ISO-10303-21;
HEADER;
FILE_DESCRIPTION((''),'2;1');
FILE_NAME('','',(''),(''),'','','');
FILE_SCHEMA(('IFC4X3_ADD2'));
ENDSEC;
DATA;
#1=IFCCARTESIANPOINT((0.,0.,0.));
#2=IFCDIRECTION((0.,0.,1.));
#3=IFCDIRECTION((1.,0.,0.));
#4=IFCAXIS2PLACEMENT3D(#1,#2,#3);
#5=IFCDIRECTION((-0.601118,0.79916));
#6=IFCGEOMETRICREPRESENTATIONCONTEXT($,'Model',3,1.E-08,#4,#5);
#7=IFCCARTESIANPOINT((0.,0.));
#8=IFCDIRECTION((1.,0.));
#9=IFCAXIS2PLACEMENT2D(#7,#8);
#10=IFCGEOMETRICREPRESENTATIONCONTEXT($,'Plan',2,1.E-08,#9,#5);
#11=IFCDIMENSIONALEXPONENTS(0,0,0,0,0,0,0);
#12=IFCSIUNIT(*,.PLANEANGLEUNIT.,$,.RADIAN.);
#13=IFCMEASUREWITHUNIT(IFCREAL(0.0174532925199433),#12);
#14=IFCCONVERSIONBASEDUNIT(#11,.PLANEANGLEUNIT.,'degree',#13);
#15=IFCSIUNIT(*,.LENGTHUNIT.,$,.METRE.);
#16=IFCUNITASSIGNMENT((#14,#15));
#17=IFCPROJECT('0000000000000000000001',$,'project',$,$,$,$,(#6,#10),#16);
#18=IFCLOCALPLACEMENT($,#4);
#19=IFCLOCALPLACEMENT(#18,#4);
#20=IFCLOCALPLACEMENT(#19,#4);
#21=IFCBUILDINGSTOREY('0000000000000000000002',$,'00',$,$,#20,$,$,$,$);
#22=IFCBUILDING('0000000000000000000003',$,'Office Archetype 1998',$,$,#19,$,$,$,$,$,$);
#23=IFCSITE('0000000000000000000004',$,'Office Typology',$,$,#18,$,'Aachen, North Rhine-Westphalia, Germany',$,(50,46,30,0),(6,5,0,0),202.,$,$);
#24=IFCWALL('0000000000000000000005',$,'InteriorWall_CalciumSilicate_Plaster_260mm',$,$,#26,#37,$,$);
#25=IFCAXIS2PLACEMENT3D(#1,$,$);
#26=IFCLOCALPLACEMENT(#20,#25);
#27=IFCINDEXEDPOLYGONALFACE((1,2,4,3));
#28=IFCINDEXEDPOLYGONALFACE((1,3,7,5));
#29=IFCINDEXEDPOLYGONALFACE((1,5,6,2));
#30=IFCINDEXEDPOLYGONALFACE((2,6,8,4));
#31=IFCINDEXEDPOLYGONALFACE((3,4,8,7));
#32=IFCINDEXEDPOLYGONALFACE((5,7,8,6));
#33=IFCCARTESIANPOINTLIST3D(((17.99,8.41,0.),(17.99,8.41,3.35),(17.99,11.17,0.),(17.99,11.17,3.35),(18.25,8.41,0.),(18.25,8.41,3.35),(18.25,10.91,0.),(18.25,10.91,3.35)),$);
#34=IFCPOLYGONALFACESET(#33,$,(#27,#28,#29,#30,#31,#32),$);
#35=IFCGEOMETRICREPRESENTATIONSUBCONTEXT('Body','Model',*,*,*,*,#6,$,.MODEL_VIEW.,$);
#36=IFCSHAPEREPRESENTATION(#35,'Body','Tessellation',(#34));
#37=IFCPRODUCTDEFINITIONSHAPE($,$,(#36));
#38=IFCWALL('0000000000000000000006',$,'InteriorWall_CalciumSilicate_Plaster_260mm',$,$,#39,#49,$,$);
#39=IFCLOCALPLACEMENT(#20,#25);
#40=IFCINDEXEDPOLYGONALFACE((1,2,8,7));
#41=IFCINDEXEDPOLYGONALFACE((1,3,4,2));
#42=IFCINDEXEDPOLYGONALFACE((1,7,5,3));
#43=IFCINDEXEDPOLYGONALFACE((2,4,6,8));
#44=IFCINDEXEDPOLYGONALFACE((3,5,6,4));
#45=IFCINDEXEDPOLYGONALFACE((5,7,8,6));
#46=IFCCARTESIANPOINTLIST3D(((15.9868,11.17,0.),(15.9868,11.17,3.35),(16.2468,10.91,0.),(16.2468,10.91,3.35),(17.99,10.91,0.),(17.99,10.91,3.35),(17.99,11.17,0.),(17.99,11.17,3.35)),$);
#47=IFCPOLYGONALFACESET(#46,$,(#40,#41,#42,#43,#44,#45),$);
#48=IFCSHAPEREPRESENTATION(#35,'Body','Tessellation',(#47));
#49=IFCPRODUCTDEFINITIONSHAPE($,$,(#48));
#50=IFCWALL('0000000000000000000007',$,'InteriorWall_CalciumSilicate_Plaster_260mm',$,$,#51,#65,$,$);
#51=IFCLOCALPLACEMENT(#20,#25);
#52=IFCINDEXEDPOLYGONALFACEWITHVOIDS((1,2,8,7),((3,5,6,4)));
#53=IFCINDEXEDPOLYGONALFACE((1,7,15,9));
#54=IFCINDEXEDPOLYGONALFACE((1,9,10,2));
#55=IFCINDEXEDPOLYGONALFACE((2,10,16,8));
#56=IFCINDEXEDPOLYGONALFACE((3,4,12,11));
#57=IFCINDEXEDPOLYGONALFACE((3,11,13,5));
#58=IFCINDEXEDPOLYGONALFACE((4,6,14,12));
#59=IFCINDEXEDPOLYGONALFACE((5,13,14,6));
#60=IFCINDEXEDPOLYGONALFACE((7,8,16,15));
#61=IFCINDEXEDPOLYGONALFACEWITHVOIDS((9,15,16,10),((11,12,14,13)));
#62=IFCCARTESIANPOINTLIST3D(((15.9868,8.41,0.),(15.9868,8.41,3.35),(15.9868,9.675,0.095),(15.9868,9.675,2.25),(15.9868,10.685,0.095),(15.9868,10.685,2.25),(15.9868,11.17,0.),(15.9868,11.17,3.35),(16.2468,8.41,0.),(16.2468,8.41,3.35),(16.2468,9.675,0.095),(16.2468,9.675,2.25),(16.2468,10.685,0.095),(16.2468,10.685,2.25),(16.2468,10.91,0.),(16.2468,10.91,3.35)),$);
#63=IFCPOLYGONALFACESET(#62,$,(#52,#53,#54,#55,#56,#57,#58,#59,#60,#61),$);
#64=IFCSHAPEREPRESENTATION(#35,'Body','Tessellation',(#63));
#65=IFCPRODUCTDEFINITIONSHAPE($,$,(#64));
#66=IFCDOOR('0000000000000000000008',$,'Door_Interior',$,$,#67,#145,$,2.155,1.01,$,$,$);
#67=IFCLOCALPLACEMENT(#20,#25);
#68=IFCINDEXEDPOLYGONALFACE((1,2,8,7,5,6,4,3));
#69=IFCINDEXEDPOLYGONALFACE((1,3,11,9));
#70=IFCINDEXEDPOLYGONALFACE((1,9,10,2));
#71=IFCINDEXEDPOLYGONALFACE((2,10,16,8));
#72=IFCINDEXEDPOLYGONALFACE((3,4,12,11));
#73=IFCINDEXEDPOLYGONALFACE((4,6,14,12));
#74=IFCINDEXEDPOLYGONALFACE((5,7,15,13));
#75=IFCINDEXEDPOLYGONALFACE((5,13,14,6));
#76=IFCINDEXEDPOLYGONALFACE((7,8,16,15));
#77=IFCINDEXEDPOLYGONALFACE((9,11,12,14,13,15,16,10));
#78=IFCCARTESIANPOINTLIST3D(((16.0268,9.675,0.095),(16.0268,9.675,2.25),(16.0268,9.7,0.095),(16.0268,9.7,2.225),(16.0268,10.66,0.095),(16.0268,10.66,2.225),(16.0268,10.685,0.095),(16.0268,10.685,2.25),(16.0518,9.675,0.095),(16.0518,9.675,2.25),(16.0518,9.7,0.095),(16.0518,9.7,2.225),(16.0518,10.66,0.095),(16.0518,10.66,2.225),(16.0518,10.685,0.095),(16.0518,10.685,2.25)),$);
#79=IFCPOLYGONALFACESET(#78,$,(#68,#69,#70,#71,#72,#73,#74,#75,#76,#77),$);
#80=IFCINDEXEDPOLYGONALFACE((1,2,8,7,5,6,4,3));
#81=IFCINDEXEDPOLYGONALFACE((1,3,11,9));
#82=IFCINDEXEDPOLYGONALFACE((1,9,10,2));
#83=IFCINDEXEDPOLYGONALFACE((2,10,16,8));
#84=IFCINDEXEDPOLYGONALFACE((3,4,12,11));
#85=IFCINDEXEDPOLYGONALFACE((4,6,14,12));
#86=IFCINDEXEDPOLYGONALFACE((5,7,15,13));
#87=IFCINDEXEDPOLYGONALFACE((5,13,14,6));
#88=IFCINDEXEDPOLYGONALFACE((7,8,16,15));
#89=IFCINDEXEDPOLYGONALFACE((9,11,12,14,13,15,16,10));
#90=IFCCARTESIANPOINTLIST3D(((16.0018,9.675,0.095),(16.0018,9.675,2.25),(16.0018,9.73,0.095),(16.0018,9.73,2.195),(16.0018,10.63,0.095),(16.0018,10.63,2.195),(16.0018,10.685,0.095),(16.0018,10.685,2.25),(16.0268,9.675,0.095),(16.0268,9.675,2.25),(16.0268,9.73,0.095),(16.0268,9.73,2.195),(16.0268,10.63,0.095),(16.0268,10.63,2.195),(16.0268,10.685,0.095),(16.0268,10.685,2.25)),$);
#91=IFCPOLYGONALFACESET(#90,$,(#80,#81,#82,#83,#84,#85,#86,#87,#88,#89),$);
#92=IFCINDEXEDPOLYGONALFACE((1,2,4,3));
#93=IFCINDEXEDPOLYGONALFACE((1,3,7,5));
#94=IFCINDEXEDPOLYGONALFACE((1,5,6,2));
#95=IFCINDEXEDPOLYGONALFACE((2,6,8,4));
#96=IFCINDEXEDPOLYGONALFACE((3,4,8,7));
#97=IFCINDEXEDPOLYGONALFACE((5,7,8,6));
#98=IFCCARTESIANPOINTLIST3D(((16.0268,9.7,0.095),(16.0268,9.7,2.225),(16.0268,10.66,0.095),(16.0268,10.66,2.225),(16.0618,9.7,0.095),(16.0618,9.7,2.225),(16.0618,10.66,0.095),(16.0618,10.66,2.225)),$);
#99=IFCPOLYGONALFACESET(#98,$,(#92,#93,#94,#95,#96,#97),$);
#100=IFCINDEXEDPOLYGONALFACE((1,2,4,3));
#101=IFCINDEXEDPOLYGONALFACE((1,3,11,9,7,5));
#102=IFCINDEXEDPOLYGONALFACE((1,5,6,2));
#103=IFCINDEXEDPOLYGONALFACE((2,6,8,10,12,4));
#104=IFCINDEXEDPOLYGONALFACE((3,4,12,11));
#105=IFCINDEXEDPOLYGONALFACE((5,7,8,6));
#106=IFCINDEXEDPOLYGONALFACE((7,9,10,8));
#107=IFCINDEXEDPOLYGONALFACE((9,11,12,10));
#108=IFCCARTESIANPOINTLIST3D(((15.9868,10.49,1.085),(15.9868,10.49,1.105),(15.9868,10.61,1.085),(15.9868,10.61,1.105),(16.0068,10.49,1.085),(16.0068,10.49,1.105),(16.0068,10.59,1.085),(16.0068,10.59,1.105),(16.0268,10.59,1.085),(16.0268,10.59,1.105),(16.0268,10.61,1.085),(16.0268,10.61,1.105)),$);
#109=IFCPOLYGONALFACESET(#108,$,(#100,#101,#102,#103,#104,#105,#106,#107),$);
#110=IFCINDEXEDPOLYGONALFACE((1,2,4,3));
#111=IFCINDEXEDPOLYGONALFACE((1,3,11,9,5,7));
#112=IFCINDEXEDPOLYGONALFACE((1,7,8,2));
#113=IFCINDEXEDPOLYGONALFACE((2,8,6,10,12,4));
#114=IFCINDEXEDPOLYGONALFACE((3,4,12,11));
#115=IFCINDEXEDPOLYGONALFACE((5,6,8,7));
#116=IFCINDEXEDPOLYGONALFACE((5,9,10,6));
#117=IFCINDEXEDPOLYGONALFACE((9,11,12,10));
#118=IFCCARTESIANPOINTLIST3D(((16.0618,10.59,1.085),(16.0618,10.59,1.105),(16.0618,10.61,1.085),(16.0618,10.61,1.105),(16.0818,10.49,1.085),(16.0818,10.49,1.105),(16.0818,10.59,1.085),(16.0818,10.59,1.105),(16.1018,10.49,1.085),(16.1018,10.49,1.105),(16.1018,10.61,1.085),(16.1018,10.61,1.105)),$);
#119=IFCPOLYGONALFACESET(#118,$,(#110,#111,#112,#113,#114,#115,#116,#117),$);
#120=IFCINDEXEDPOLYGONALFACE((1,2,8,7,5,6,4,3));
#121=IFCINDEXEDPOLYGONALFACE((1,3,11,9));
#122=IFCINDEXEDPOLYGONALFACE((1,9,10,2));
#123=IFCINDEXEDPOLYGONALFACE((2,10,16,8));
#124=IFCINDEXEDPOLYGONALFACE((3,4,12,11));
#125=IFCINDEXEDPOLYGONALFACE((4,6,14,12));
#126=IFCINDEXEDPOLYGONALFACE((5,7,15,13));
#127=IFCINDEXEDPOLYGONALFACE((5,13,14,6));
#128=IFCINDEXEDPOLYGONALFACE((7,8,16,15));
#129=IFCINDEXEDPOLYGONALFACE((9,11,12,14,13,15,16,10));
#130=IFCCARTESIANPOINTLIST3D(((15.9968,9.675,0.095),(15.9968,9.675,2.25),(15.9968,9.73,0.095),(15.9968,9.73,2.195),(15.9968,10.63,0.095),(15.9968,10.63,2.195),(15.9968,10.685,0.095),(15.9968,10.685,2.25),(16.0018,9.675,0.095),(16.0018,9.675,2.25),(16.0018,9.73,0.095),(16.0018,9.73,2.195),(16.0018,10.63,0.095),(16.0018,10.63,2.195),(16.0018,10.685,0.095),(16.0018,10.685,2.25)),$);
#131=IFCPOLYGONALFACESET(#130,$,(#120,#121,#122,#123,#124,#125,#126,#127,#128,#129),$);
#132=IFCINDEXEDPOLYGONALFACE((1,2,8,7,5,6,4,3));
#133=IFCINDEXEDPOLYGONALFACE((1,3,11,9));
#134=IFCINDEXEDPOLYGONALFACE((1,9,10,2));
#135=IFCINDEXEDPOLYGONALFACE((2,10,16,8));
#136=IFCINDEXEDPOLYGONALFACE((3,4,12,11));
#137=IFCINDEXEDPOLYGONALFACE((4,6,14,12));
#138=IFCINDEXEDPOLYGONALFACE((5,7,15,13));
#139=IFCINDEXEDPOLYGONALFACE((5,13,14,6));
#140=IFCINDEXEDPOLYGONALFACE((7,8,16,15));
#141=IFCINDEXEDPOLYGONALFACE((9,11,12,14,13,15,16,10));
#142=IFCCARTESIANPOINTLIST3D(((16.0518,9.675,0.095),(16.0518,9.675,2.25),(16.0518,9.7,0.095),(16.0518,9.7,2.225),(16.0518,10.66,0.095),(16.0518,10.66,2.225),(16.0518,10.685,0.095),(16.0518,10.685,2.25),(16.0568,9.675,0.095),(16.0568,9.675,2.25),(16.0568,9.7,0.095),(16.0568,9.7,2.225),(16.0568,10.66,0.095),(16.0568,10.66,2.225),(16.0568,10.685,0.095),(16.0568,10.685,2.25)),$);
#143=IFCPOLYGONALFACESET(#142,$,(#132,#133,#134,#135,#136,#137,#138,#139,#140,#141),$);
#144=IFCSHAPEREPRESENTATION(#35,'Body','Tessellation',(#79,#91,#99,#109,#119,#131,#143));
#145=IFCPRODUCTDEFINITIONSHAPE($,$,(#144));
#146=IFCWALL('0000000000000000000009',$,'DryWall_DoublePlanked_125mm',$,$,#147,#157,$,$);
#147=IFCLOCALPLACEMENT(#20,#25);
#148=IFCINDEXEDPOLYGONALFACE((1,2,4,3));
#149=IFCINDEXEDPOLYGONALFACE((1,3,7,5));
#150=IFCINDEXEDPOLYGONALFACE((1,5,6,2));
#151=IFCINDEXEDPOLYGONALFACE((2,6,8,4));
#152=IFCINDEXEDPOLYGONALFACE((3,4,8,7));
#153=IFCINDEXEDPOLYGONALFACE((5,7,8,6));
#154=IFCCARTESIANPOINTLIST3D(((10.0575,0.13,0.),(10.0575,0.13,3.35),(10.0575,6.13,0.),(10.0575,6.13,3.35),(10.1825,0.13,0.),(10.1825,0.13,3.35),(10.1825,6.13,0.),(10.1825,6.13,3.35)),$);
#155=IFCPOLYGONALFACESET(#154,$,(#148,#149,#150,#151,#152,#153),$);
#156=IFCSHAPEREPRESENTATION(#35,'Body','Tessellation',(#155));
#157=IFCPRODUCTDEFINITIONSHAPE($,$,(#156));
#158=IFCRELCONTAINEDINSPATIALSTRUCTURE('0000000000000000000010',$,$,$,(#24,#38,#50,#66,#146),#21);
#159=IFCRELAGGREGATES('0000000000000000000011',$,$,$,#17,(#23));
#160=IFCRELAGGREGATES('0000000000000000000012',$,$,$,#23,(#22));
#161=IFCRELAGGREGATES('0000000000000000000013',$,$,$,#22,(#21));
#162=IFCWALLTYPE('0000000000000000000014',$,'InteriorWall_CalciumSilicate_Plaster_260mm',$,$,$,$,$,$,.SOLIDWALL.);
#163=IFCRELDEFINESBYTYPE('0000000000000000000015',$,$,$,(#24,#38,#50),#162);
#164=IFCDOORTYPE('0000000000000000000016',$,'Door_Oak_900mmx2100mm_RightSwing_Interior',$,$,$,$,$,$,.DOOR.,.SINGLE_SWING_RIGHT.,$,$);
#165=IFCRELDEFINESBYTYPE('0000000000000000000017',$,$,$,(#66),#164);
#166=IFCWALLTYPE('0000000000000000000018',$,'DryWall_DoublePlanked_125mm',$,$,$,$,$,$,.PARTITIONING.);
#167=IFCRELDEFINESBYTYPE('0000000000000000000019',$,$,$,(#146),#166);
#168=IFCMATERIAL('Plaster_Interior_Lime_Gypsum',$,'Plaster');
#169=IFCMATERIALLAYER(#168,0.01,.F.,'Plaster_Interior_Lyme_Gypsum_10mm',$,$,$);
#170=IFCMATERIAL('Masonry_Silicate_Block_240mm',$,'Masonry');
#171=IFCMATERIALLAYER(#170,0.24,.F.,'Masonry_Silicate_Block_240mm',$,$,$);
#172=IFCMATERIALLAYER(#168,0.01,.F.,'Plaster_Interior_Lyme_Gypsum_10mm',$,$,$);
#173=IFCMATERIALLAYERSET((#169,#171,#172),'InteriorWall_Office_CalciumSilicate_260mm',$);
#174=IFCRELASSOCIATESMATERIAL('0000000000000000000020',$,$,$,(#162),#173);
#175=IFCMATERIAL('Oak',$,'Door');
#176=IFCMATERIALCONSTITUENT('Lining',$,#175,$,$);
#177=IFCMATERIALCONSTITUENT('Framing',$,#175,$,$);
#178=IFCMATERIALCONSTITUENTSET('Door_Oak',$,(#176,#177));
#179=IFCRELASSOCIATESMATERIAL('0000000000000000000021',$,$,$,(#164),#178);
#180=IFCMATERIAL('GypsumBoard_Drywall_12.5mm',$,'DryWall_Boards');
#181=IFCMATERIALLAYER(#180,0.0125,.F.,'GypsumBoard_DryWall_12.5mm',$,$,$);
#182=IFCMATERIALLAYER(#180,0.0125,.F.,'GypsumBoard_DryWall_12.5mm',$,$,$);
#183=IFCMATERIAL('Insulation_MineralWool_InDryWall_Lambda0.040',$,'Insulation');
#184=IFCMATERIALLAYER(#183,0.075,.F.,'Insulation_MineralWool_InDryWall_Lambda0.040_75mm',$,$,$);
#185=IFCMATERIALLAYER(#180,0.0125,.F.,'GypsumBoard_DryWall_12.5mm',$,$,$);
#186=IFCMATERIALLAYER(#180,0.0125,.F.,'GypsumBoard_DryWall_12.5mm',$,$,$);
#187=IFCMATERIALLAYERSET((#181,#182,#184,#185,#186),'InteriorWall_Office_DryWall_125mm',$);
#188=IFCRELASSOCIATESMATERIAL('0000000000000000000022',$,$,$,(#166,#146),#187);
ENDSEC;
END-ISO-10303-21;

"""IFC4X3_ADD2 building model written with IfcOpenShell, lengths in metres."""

from ifc_helpers import new_model, entity, si_unit, converted_unit, direction, frame, origin_with_axes, origin_2d_with_axis, place, context, subcontext, project, spatial, line, indexed_curve, outline, extrude, source, transform, mapped, material, layer, layer_set, layer_usage, constituent, constituent_set, type_object, type_shapes, element, fill, save


model = new_model("IFC4X3_ADD2")

# Units and contexts
model_context = context("Model", 3, precision=1e-08, world=origin_with_axes(), true_north=direction((-0.601118, 0.79916)))
plan_context = context("Plan", 2, precision=1e-08, world=origin_2d_with_axis(), true_north=direction((-0.601118, 0.79916)))
body_context = subcontext(model_context, "Body", "Model", "MODEL_VIEW")
ifc_project = project(units=[converted_unit("PLANEANGLEUNIT", "degree", entity("IfcReal", 0.0174532925199433), si_unit("PLANEANGLEUNIT", "RADIAN"), dimensions=[0, 0, 0, 0, 0, 0, 0]), si_unit("LENGTHUNIT", "METRE")], contexts=[model_context, plan_context])

# Site, building, storey
site_placement = place(None, origin_with_axes())
site = spatial("IfcSite", under=ifc_project, at=site_placement, Name="Office Typology", LongName="Aachen, North Rhine-Westphalia, Germany", RefLatitude=(50, 46, 30, 0), RefLongitude=(6, 5, 0, 0), RefElevation=202.0)
building_placement = place(site_placement, origin_with_axes())
building = spatial("IfcBuilding", under=site, at=building_placement, Name="Office Archetype 1998")
storey_placement = place(building_placement, origin_with_axes())
storey = spatial("IfcBuildingStorey", under=building, at=storey_placement, Name="00")

# Walls
ifc_material_1 = material(Name="Plaster_Interior_Lime_Gypsum", Category="Plaster")
ifc_layer_1 = layer(ifc_material_1, 0.01, ventilated=False, Name="Plaster_Interior_Lyme_Gypsum_10mm")
ifc_material_2 = material(Name="Masonry_Silicate_Block_240mm", Category="Masonry")
ifc_layer_2 = layer(ifc_material_2, 0.24, ventilated=False, Name="Masonry_Silicate_Block_240mm")
ifc_layer_3 = layer(ifc_material_1, 0.01, ventilated=False, Name="Plaster_Interior_Lyme_Gypsum_10mm")
ifc_layer_set_1 = layer_set([ifc_layer_1, ifc_layer_2, ifc_layer_3], Name="InteriorWall_Office_CalciumSilicate_260mm")
wall_type_1 = type_object("IfcWallType", Name="InteriorWall_CalciumSilicate_Plaster_260mm", PredefinedType="SOLIDWALL", material=ifc_layer_set_1)
wall_1_placement = place(storey_placement, frame((17.99, 11.17, 0.0), z_axis=(0.0, 0.0, 1.0), x_axis=(0.0, -1.0, 0.0)))
element("IfcWall", 1, at=wall_1_placement, inside=storey, type_object=wall_type_1, Name="InteriorWall_CalciumSilicate_Plaster_260mm", context=body_context, shape_type="SweptSolid", body=[
    extrude(outline(indexed_curve([(0.0, 0.0), (0.26, 0.26), (2.76, 0.26), (2.76, 0.0)], segments=[line(1, 2, 3, 4, 1)])), origin_with_axes(), (0.0, 0.0, 1.0), 3.35),
])
wall_2_placement = place(storey_placement, frame((17.99, 11.17, 0.0), z_axis=(0.0, 0.0, 1.0), x_axis=(-1.0, 0.0, 0.0)))
element("IfcWall", 2, at=wall_2_placement, inside=storey, type_object=wall_type_1, Name="InteriorWall_CalciumSilicate_Plaster_260mm", context=body_context, shape_type="SweptSolid", body=[
    extrude(outline(indexed_curve([(0.0, 0.0), (0.0, 0.26), (1.7432, 0.26), (2.0032, 0.0)], segments=[line(1, 2, 3, 4, 1)])), origin_with_axes(), (0.0, 0.0, 1.0), 3.35),
])

# Wall, opening, door
wall_3_placement = place(storey_placement, frame((15.9868, 11.17, 0.0), z_axis=(0.0, 0.0, 1.0), x_axis=(0.0, -1.0, 0.0)))
wall_3 = element("IfcWall", 3, at=wall_3_placement, inside=storey, type_object=wall_type_1, Name="InteriorWall_CalciumSilicate_Plaster_260mm", context=body_context, shape_type="SweptSolid", body=[
    extrude(outline(indexed_curve([(0.0, 0.0), (0.26, 0.26), (2.76, 0.26), (2.76, 0.0)], segments=[line(1, 2, 3, 4, 1)])), origin_with_axes(), (0.0, 0.0, 1.0), 3.35),
])
shared_shape_1 = source(origin_with_axes(), body_context, "Body", "SweptSolid", [
    extrude(outline(indexed_curve([(0.0, 2.155), (1.01, 2.155), (1.01, 0.0), (0.0, 0.0), (0.0, 2.155)])), frame((0.0, 0.0, 0.0), z_axis=(0.0, -1.0, 0.0), x_axis=(1.0, 0.0, 0.0)), (0.0, 0.0, -1.0), 0.26),
])
opening_1_placement = place(wall_3_placement, frame((0.485, 0.0, 0.095), z_axis=(0.0, 0.0, 1.0), x_axis=(1.0, 0.0, 0.0)))
opening_1 = element("IfcOpeningElement", 4, at=opening_1_placement, cuts=wall_3, PredefinedType="OPENING", context=body_context, shape_type="MappedRepresentation", body=[
    mapped(shared_shape_1, transform((0.0, 0.0, 0.0), x_axis=(1.0, 0.0, 0.0), y_axis=(0.0, 1.0, 0.0), z_axis=(0.0, 0.0, 1.0), scale=1.0)),
])
ifc_material_3 = material(Name="Oak", Category="Door")
ifc_constituent_1 = constituent(ifc_material_3, Name="Lining")
ifc_constituent_2 = constituent(ifc_material_3, Name="Framing")
ifc_constituent_set_1 = constituent_set(constituents=[ifc_constituent_1, ifc_constituent_2], Name="Door_Oak")
door_type_1 = type_object("IfcDoorType", Name="Door_Oak_900mmx2100mm_RightSwing_Interior", OperationType="SINGLE_SWING_RIGHT", PredefinedType="DOOR", material=ifc_constituent_set_1)
shared_shape_2 = source(origin_with_axes(), body_context, "Body", "SweptSolid", [
    extrude(outline(indexed_curve([(0.0, 0.0), (0.0, 2.155), (1.01, 2.155), (1.01, 0.0), (0.985, 0.0), (0.985, 2.13), (0.025, 2.13), (0.025, 0.0)], segments=[line(1, 2, 3, 4, 5, 6, 7, 8, 1)])), frame((0.0, 0.025, 0.0), z_axis=(0.0, -1.0, 0.0), x_axis=(1.0, 0.0, 0.0)), (0.0, 0.0, -1.0), 0.025),
    extrude(outline(indexed_curve([(0.0, 0.0), (0.0, 2.155), (1.01, 2.155), (1.01, 0.0), (0.955, 0.0), (0.955, 2.1), (0.055, 2.1), (0.055, 0.0)], segments=[line(1, 2, 3, 4, 5, 6, 7, 8, 1)])), frame((0.0, 0.0, 0.0), z_axis=(0.0, -1.0, 0.0), x_axis=(1.0, 0.0, 0.0)), (0.0, 0.0, -1.0), 0.025),
    extrude(outline(indexed_curve([(0.0, 0.0), (0.96, 0.0), (0.96, 0.035), (0.0, 0.035)], segments=[line(1, 2, 3, 4, 1)])), frame((0.025, 0.025, 0.0), z_axis=(0.0, 0.0, 1.0), x_axis=(1.0, 0.0, 0.0)), (0.0, 0.0, 1.0), 2.13),
    extrude(outline(indexed_curve([(0.0, 0.0), (0.0, -0.04), (0.12, -0.04), (0.12, -0.02), (0.02, -0.02), (0.02, 0.0)], segments=[line(1, 2, 3, 4, 5, 6, 1)])), frame((0.075, 0.025, 0.99), z_axis=(0.0, 0.0, 1.0), x_axis=(1.0, 0.0, 0.0)), (0.0, 0.0, 1.0), 0.02),
    extrude(outline(indexed_curve([(0.0, 0.0), (0.0, 0.04), (0.12, 0.04), (0.12, 0.02), (0.02, 0.02), (0.02, 0.0)], segments=[line(1, 2, 3, 4, 5, 6, 1)])), frame((0.075, 0.06, 0.99), z_axis=(0.0, 0.0, 1.0), x_axis=(1.0, 0.0, 0.0)), (0.0, 0.0, 1.0), 0.02),
    extrude(outline(indexed_curve([(0.0, 0.0), (0.0, 2.155), (1.01, 2.155), (1.01, 0.0), (0.955, 0.0), (0.955, 2.1), (0.055, 2.1), (0.055, 0.0)], segments=[line(1, 2, 3, 4, 5, 6, 7, 8, 1)])), frame((0.0, -0.005, 0.0), z_axis=(0.0, -1.0, 0.0), x_axis=(1.0, 0.0, 0.0)), (0.0, 0.0, -1.0), 0.005),
    extrude(outline(indexed_curve([(0.0, 0.0), (0.0, 2.155), (1.01, 2.155), (1.01, 0.0), (0.985, 0.0), (0.985, 2.13), (0.025, 2.13), (0.025, 0.0)], segments=[line(1, 2, 3, 4, 5, 6, 7, 8, 1)])), frame((0.0, 0.05, 0.0), z_axis=(0.0, -1.0, 0.0), x_axis=(1.0, 0.0, 0.0)), (0.0, 0.0, -1.0), 0.005),
])
type_shapes(door_type_1, [shared_shape_2])
door_1_placement = place(opening_1_placement, frame((0.0, 0.015, 0.0), z_axis=(0.0, 0.0, 1.0), x_axis=(1.0, 0.0, 0.0)))
door_1 = element("IfcDoor", 5, at=door_1_placement, inside=storey, type_object=door_type_1, Name="Door_Interior", OverallHeight=2.155, OverallWidth=1.01, context=body_context, shape_type="MappedRepresentation", body=[
    mapped(shared_shape_2, transform((0.0, 0.0, 0.0), x_axis=(1.0, 0.0, 0.0), y_axis=(0.0, 1.0, 0.0), z_axis=(0.0, 0.0, 1.0), scale=1.0)),
])
fill(opening_1, door_1)

# Wall
ifc_material_4 = material(Name="GypsumBoard_Drywall_12.5mm", Category="DryWall_Boards")
ifc_layer_4 = layer(ifc_material_4, 0.0125, ventilated=False, Name="GypsumBoard_DryWall_12.5mm")
ifc_layer_5 = layer(ifc_material_4, 0.0125, ventilated=False, Name="GypsumBoard_DryWall_12.5mm")
ifc_material_5 = material(Name="Insulation_MineralWool_InDryWall_Lambda0.040", Category="Insulation")
ifc_layer_6 = layer(ifc_material_5, 0.075, ventilated=False, Name="Insulation_MineralWool_InDryWall_Lambda0.040_75mm")
ifc_layer_7 = layer(ifc_material_4, 0.0125, ventilated=False, Name="GypsumBoard_DryWall_12.5mm")
ifc_layer_8 = layer(ifc_material_4, 0.0125, ventilated=False, Name="GypsumBoard_DryWall_12.5mm")
ifc_layer_set_2 = layer_set([ifc_layer_4, ifc_layer_5, ifc_layer_6, ifc_layer_7, ifc_layer_8], Name="InteriorWall_Office_DryWall_125mm")
wall_type_2 = type_object("IfcWallType", Name="DryWall_DoublePlanked_125mm", PredefinedType="PARTITIONING", material=ifc_layer_set_2)
ifc_layer_usage_1 = layer_usage(ifc_layer_set_2, "AXIS2", "POSITIVE", 0.0)
wall_4_placement = place(storey_placement, frame((10.0575, 6.13, 0.0), z_axis=(0.0, 0.0, 1.0), x_axis=(0.0, -1.0, 0.0)))
element("IfcWall", 6, at=wall_4_placement, inside=storey, type_object=wall_type_2, material=ifc_layer_usage_1, Name="DryWall_DoublePlanked_125mm", context=body_context, shape_type="SweptSolid", body=[
    extrude(outline(indexed_curve([(0.0, 0.0), (0.0, 0.125), (6.0, 0.125), (6.0, 0.0)], segments=[line(1, 2, 3, 4, 1)])), origin_with_axes(), (0.0, 0.0, 1.0), 3.35),
])

save(model, "model.ifc")
